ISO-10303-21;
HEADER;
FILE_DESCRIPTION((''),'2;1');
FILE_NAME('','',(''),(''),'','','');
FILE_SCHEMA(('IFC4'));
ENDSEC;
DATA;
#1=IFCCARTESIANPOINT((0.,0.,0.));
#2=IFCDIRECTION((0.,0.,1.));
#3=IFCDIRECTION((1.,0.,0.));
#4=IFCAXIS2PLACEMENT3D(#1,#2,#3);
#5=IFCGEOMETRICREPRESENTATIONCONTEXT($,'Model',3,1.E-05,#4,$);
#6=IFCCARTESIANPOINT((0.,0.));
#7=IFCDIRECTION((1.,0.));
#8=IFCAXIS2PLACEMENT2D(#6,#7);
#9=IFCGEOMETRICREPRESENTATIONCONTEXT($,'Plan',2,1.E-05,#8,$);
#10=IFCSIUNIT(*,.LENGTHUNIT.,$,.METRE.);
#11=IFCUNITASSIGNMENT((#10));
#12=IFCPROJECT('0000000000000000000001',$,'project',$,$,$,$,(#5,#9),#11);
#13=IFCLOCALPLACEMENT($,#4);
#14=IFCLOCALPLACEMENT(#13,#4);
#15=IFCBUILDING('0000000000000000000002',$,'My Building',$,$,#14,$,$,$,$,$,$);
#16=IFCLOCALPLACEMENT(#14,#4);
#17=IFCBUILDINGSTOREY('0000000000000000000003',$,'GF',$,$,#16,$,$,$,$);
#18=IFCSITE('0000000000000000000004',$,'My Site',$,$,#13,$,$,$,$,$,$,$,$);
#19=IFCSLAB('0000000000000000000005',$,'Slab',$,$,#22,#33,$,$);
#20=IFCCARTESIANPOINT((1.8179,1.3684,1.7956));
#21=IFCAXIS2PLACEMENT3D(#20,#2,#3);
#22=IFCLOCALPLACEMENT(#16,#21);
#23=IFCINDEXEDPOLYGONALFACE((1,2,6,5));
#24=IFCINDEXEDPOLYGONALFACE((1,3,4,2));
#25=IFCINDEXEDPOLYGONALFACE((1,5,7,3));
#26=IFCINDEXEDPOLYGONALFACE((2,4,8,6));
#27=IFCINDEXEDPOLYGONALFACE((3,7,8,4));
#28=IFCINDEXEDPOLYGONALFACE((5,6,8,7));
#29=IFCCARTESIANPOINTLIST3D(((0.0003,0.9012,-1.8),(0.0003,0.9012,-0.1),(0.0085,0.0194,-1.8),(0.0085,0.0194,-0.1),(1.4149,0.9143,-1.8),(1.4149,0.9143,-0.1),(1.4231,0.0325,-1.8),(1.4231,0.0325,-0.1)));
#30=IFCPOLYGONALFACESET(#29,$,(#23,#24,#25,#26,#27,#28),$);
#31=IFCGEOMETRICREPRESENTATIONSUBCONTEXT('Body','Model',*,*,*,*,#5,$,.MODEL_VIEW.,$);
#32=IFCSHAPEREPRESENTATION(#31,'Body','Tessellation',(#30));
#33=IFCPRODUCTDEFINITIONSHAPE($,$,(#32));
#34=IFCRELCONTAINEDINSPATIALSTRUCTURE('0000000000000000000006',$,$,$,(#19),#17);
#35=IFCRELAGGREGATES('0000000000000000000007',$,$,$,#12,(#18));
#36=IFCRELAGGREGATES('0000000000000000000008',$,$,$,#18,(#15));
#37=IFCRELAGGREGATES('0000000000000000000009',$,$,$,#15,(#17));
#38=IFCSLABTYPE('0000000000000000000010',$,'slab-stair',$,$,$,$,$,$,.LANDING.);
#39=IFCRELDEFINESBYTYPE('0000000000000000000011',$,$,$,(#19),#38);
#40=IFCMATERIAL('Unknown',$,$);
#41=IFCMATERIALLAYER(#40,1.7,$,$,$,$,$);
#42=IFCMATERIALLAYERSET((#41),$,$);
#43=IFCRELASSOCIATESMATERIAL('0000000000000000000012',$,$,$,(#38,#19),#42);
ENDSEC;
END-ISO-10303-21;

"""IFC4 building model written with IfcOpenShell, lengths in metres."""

from ifc_helpers import new_model, si_unit, frame, origin_with_axes, origin_2d_with_axis, place, context, subcontext, project, spatial, indexed_curve, outline, extrude, material, layer, layer_set, layer_usage, type_object, element, save


model = new_model("IFC4")

# Units and contexts
model_context = context("Model", 3, precision=1e-05, world=origin_with_axes())
plan_context = context("Plan", 2, precision=1e-05, world=origin_2d_with_axis())
body_context_1 = subcontext(model_context, "Body", "Model", "MODEL_VIEW")
ifc_project = project(units=[si_unit("LENGTHUNIT", "METRE")], contexts=[model_context, plan_context])

# Site, building, storey
site_placement = place(None, origin_with_axes())
site = spatial("IfcSite", under=ifc_project, at=site_placement, Name="My Site")
building_placement = place(site_placement, origin_with_axes())
building = spatial("IfcBuilding", under=site, at=building_placement, Name="My Building")
storey_placement = place(building_placement, origin_with_axes())
storey = spatial("IfcBuildingStorey", under=building, at=storey_placement, Name="GF")

# Slab
ifc_material_1 = material(Name="Unknown")
ifc_layer_1 = layer(ifc_material_1, 1.7)
ifc_layer_set_1 = layer_set([ifc_layer_1])
ifc_layer_usage_1 = layer_usage(ifc_layer_set_1, "AXIS3", "POSITIVE", -1.8)
slab_type_1 = type_object("IfcSlabType", Name="slab-stair", PredefinedType="LANDING", material=ifc_layer_set_1)
slab_1_placement = place(storey_placement, frame((1.8179, 1.3684, 1.7956), z_axis=(0.0, 0.0, 1.0), x_axis=(1.0, 0.0, 0.0)))
element("IfcSlab", 1, at=slab_1_placement, inside=storey, type_object=slab_type_1, material=ifc_layer_usage_1, Name="Slab", context=body_context_1, shape_type="SweptSolid", body=[
    extrude(outline(indexed_curve([(0.0085, 0.0194), (0.0003, 0.9012), (1.4149, 0.9143), (1.4231, 0.0325), (0.0085, 0.0194)])), frame((0.0, 0.0, -1.8), z_axis=(0.0, 0.0, 1.0), x_axis=(1.0, 0.0, 0.0)), (0.0, 0.0, 1.0), 1.7),
])

save(model, "model.ifc")
